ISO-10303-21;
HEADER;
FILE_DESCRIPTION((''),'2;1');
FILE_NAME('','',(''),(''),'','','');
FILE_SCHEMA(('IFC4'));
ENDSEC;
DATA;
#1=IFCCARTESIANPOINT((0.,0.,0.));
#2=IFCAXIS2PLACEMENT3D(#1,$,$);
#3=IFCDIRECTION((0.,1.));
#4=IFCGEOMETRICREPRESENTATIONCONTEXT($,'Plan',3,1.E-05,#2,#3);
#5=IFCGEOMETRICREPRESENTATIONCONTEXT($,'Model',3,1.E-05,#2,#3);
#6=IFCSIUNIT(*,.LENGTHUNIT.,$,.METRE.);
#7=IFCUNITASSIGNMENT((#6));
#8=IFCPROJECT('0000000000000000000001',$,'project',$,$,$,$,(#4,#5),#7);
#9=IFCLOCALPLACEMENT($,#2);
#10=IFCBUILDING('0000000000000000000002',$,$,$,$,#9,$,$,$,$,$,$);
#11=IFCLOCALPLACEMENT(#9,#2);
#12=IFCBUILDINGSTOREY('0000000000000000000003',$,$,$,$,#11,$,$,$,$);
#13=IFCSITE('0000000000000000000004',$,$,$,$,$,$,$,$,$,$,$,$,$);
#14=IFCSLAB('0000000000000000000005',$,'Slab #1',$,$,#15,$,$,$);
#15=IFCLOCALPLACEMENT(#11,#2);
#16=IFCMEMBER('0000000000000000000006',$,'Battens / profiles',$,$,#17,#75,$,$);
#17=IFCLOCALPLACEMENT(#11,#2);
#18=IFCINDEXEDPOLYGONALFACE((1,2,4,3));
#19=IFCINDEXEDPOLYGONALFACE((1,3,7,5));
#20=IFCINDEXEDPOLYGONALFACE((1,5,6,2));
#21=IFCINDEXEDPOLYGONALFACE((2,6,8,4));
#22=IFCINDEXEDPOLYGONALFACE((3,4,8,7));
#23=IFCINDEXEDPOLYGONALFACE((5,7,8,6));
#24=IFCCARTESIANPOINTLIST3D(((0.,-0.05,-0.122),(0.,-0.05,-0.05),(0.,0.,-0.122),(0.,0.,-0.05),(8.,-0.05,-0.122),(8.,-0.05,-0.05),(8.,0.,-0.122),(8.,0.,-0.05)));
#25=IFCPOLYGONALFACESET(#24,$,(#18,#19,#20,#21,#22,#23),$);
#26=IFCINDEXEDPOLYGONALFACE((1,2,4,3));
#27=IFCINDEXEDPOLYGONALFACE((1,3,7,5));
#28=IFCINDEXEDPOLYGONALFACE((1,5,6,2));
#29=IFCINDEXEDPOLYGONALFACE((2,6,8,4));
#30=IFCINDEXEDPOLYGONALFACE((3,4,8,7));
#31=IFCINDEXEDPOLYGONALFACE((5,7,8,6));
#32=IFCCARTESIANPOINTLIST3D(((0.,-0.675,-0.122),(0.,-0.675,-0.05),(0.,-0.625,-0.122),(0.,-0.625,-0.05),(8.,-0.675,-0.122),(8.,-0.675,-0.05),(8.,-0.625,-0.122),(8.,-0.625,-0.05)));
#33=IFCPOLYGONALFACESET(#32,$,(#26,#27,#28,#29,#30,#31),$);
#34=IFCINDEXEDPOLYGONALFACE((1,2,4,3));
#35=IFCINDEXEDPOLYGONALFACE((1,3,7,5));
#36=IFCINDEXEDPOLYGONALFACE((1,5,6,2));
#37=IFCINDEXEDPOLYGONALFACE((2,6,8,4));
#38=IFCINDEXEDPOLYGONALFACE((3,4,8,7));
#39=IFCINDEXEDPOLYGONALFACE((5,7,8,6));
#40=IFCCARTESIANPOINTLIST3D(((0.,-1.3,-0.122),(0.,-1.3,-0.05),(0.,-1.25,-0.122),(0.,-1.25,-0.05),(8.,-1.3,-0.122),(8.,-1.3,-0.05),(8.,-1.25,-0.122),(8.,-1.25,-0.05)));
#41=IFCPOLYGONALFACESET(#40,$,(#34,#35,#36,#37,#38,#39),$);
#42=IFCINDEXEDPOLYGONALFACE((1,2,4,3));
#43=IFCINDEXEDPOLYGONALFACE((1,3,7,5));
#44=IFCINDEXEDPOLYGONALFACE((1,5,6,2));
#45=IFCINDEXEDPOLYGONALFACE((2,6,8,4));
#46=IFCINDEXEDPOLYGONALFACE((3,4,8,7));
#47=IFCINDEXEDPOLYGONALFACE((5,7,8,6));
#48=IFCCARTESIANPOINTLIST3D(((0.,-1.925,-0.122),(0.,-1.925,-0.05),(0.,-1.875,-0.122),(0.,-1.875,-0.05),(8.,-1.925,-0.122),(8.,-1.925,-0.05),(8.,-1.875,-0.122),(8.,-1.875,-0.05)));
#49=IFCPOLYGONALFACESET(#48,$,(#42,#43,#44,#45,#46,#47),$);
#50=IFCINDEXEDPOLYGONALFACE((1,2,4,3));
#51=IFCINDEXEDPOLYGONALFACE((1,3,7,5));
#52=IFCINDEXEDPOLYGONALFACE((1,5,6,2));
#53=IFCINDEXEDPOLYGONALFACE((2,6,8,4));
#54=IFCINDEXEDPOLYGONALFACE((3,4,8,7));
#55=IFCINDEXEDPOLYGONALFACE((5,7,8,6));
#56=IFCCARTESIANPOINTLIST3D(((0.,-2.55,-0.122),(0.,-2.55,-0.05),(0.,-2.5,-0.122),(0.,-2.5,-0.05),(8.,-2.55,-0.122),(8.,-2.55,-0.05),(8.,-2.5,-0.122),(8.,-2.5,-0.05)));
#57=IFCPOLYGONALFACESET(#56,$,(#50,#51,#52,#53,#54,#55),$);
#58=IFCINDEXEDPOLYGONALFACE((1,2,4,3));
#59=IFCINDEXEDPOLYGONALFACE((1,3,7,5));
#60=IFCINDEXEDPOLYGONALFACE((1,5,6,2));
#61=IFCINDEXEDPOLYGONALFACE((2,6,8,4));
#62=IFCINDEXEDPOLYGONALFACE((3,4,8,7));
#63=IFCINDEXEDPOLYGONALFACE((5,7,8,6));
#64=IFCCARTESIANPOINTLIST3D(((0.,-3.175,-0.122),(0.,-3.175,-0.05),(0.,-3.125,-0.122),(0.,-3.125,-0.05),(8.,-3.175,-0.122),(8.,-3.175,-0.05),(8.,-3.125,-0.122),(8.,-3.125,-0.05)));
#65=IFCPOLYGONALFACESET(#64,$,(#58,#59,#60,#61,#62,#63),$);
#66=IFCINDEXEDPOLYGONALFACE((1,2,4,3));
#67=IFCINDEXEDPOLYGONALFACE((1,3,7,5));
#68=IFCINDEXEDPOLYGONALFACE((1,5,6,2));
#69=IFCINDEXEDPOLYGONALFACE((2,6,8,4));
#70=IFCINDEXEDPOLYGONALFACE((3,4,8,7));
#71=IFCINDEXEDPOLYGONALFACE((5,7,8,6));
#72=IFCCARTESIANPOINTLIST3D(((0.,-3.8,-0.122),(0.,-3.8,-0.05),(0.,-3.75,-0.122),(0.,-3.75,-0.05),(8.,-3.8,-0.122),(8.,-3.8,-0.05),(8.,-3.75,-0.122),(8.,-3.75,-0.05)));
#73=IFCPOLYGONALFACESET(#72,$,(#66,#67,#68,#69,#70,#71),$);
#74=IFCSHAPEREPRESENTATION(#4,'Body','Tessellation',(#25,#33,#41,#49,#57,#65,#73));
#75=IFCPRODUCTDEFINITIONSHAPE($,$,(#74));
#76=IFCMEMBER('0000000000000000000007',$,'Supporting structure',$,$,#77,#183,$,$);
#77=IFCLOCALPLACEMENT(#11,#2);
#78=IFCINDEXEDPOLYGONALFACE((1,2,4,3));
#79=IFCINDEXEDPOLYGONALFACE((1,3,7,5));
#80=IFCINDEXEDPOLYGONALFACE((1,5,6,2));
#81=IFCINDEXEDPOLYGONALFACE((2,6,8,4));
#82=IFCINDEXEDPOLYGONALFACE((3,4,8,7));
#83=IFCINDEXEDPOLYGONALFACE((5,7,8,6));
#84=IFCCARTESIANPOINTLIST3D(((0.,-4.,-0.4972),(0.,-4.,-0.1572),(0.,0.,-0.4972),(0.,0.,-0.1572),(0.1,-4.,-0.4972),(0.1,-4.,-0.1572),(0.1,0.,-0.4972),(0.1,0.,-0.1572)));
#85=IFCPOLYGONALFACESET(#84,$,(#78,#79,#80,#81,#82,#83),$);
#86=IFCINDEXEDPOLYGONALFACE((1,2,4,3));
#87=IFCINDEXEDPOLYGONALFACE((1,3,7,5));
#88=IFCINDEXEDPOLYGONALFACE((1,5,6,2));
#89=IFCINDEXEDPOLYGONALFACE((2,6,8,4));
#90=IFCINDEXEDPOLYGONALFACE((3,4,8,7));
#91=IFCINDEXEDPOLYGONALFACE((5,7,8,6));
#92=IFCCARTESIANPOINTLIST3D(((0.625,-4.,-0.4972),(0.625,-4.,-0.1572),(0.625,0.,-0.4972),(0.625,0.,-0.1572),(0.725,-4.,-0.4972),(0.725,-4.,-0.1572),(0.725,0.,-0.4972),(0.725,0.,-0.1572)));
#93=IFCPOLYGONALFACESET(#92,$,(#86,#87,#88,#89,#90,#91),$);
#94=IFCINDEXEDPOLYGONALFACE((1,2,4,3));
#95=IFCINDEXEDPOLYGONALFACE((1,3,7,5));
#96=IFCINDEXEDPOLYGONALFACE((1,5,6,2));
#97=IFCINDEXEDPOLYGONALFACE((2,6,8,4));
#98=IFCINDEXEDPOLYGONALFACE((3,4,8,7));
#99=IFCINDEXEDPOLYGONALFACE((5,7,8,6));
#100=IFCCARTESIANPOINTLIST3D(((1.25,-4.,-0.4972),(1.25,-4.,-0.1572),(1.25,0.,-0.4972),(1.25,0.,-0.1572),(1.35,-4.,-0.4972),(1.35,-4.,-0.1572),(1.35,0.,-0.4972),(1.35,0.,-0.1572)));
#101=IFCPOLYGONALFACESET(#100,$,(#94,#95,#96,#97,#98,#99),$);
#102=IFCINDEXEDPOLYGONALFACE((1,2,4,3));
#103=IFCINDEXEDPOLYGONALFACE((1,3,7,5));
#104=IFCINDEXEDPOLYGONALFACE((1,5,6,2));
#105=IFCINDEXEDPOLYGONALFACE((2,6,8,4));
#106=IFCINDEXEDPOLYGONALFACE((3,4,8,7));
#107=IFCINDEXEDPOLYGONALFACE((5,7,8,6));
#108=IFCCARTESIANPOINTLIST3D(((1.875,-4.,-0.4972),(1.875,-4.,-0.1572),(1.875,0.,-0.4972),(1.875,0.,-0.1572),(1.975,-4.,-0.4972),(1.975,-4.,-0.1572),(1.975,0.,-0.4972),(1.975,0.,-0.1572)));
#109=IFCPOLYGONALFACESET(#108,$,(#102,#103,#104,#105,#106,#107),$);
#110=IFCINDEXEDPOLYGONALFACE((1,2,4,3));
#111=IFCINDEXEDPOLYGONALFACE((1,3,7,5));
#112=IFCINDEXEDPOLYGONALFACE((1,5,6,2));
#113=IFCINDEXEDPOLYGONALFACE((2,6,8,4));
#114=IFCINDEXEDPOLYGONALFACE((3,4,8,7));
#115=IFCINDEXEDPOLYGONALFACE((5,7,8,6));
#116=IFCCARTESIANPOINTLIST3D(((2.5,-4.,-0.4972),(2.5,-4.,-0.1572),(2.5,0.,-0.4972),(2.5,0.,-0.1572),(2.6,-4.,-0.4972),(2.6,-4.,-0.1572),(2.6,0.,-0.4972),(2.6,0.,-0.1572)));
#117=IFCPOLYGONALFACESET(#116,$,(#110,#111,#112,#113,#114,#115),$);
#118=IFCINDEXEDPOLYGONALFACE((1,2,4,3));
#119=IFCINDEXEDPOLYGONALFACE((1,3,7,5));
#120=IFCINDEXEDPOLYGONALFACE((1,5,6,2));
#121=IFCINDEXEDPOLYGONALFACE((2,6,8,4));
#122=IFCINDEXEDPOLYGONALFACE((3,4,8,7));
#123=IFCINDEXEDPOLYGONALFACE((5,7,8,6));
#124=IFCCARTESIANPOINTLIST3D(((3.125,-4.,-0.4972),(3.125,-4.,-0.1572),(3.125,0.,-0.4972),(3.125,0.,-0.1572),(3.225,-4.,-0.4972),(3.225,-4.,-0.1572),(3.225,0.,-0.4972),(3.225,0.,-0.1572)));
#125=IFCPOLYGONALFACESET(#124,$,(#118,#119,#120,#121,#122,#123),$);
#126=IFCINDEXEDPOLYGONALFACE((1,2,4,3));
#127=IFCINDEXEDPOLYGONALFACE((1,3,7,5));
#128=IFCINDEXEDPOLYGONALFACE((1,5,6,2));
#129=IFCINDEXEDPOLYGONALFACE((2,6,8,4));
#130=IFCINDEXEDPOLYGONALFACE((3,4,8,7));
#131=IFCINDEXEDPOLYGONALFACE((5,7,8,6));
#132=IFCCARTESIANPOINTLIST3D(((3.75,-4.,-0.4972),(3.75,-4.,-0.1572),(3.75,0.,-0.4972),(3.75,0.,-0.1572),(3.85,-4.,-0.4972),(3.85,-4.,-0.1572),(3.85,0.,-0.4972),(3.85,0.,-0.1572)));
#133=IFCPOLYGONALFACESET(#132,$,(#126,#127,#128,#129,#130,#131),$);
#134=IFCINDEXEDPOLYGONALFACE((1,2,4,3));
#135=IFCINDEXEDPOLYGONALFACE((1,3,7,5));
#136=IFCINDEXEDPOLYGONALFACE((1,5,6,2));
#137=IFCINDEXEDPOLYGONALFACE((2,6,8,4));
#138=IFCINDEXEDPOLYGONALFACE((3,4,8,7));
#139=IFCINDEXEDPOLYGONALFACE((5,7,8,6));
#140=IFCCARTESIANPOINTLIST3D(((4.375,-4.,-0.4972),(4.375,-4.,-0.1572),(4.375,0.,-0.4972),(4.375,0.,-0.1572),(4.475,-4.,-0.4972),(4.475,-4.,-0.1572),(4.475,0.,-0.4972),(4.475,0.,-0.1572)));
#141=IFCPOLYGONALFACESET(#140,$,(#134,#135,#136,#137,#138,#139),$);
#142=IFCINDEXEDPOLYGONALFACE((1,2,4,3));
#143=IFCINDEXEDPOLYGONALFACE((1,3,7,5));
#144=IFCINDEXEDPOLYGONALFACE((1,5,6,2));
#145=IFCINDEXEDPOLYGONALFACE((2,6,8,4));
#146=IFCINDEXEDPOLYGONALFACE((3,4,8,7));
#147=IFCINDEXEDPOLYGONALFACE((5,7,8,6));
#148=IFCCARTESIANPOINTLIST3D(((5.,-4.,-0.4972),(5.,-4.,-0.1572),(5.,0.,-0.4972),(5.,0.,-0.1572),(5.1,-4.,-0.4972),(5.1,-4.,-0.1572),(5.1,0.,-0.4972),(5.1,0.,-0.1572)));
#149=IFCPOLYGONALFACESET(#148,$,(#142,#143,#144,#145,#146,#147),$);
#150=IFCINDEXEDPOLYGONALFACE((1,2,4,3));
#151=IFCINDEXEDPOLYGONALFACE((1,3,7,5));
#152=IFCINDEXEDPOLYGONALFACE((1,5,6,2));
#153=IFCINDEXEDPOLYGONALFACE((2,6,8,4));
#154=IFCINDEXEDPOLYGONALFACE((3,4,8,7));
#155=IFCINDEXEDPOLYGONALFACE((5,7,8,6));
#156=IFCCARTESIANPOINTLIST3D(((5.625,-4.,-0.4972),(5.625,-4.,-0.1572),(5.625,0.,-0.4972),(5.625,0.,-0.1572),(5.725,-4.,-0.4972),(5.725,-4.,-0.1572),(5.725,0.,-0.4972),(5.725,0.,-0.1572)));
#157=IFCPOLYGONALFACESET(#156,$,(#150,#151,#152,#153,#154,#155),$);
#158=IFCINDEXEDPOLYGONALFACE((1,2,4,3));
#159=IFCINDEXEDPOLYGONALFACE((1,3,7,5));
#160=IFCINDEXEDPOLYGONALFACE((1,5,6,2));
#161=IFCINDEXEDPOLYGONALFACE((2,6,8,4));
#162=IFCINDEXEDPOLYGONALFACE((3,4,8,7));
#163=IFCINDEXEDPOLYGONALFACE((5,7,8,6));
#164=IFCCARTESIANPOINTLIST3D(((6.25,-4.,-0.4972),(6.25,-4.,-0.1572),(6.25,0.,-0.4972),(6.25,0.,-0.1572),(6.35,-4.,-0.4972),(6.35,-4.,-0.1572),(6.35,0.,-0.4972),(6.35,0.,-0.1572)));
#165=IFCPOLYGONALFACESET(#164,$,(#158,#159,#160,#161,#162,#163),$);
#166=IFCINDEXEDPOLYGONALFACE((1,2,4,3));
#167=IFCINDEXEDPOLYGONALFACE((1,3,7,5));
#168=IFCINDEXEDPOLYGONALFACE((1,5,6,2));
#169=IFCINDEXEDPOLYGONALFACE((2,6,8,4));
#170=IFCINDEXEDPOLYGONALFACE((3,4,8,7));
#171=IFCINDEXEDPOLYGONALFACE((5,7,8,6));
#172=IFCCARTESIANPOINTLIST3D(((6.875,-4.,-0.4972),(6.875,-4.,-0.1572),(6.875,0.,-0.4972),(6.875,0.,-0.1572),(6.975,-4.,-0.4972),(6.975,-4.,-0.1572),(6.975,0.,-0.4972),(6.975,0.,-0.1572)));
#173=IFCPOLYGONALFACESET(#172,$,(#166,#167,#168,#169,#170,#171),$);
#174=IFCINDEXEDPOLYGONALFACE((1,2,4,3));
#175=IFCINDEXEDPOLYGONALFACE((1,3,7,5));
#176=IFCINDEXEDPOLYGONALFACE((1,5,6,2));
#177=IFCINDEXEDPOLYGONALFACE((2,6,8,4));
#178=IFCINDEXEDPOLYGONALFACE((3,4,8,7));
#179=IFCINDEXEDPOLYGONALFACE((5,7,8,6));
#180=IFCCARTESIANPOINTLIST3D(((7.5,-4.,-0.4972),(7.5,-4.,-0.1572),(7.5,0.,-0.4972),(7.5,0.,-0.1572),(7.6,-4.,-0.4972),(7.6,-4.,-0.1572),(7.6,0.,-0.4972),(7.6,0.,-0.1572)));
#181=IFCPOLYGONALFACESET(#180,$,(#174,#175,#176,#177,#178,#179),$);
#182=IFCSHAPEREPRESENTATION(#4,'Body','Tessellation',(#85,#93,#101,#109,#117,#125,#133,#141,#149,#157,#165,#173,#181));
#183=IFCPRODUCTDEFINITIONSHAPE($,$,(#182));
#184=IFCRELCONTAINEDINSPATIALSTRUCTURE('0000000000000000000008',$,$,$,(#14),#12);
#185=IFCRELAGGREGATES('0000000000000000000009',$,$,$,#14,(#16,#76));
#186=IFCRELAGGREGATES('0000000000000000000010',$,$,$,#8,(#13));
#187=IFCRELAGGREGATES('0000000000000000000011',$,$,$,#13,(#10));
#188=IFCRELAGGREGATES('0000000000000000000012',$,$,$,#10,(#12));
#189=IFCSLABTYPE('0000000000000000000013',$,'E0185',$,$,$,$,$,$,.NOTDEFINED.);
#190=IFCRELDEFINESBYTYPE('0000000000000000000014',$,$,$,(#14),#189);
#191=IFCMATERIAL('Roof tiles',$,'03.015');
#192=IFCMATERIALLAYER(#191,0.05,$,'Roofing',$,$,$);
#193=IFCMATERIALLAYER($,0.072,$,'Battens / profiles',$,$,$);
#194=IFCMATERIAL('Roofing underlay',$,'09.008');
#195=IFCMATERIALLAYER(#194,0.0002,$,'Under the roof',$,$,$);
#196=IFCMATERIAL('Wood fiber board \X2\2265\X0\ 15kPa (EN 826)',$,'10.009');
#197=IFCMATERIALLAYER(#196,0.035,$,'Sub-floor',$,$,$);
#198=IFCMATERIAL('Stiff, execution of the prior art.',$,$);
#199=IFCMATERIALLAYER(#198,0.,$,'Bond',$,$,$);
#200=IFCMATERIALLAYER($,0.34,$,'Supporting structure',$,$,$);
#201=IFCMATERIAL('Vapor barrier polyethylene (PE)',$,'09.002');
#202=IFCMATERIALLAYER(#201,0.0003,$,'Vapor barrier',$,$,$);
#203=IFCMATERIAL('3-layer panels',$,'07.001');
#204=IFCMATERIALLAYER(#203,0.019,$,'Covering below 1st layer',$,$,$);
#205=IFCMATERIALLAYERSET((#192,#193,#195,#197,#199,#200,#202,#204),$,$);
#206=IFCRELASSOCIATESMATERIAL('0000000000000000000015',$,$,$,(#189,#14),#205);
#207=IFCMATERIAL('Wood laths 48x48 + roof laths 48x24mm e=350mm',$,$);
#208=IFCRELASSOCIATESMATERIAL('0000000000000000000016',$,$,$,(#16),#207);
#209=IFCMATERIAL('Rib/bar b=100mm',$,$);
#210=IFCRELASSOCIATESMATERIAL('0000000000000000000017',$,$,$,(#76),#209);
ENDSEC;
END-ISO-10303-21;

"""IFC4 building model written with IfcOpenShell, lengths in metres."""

from ifc_helpers import new_model, si_unit, direction, frame, frame_2d, origin, place, context, project, spatial, rectangle, extrude, material, layer, layer_set, type_object, element, aggregate, save


model = new_model("IFC4")

# Units and contexts
plan_context = context("Plan", 3, precision=1e-05, world=origin(), true_north=direction((0.0, 1.0)))
model_context = context("Model", 3, precision=1e-05, world=origin(), true_north=direction((0.0, 1.0)))
ifc_project = project(units=[si_unit("LENGTHUNIT", "METRE")], contexts=[plan_context, model_context])

# Site, building, storey
site = spatial("IfcSite", under=ifc_project)
building_placement = place(None, origin())
building = spatial("IfcBuilding", under=site, at=building_placement)
storey_placement = place(building_placement, origin())
storey = spatial("IfcBuildingStorey", under=building, at=storey_placement)

# Slab, members
ifc_material_1 = material(Name="Roof tiles", Category="03.015")
ifc_layer_1 = layer(ifc_material_1, 0.05, Name="Roofing")
ifc_layer_2 = layer(None, 0.072, Name="Battens / profiles")
ifc_material_2 = material(Name="Roofing underlay", Category="09.008")
ifc_layer_3 = layer(ifc_material_2, 0.0002, Name="Under the roof")
ifc_material_3 = material(Name="Wood fiber board ≥ 15kPa (EN 826)", Category="10.009")
ifc_layer_4 = layer(ifc_material_3, 0.035, Name="Sub-floor")
ifc_material_4 = material(Name="Stiff, execution of the prior art.")
ifc_layer_5 = layer(ifc_material_4, 0.0, Name="Bond")
ifc_layer_6 = layer(None, 0.34, Name="Supporting structure")
ifc_material_5 = material(Name="Vapor barrier polyethylene (PE)", Category="09.002")
ifc_layer_7 = layer(ifc_material_5, 0.0003, Name="Vapor barrier")
ifc_material_6 = material(Name="3-layer panels", Category="07.001")
ifc_layer_8 = layer(ifc_material_6, 0.019, Name="Covering below 1st layer")
ifc_layer_set = layer_set([ifc_layer_1, ifc_layer_2, ifc_layer_3, ifc_layer_4, ifc_layer_5, ifc_layer_6, ifc_layer_7, ifc_layer_8])
slab_type = type_object("IfcSlabType", Name="E0185", PredefinedType="NOTDEFINED", material=ifc_layer_set)
slab_placement = place(None, frame((0.0, 0.0, 0.0), z_axis=(0.0, 0.0, -1.0), x_axis=(1.0, 0.0, 0.0)))
slab = element("IfcSlab", 1, at=slab_placement, inside=storey, type_object=slab_type, material=ifc_layer_set, Name="Slab #1")
ifc_material_7 = material(Name="Wood laths 48x48 + roof laths 48x24mm e=350mm")
member_1_placement = place(slab_placement, origin())
member_1 = element("IfcMember", 2, at=member_1_placement, material=ifc_material_7, Name="Battens / profiles", context=plan_context, shape_type="SweptSolid", body=[
    extrude(rectangle(XDim=0.05, YDim=0.072, at=frame_2d((0.025, 0.036), x_axis=(1.0, 0.0))), frame((0.0, 0.0, 0.05), z_axis=(1.0, 0.0, 0.0), x_axis=(0.0, 1.0, 0.0)), (0.0, 0.0, 1.0), 8.0),
    extrude(rectangle(XDim=0.05, YDim=0.072, at=frame_2d((0.025, 0.036), x_axis=(1.0, 0.0))), frame((0.0, 0.625, 0.05), z_axis=(1.0, 0.0, 0.0), x_axis=(0.0, 1.0, 0.0)), (0.0, 0.0, 1.0), 8.0),
    extrude(rectangle(XDim=0.05, YDim=0.072, at=frame_2d((0.025, 0.036), x_axis=(1.0, 0.0))), frame((0.0, 1.25, 0.05), z_axis=(1.0, 0.0, 0.0), x_axis=(0.0, 1.0, 0.0)), (0.0, 0.0, 1.0), 8.0),
    extrude(rectangle(XDim=0.05, YDim=0.072, at=frame_2d((0.025, 0.036), x_axis=(1.0, 0.0))), frame((0.0, 1.875, 0.05), z_axis=(1.0, 0.0, 0.0), x_axis=(0.0, 1.0, 0.0)), (0.0, 0.0, 1.0), 8.0),
    extrude(rectangle(XDim=0.05, YDim=0.072, at=frame_2d((0.025, 0.036), x_axis=(1.0, 0.0))), frame((0.0, 2.5, 0.05), z_axis=(1.0, 0.0, 0.0), x_axis=(0.0, 1.0, 0.0)), (0.0, 0.0, 1.0), 8.0),
    extrude(rectangle(XDim=0.05, YDim=0.072, at=frame_2d((0.025, 0.036), x_axis=(1.0, 0.0))), frame((0.0, 3.125, 0.05), z_axis=(1.0, 0.0, 0.0), x_axis=(0.0, 1.0, 0.0)), (0.0, 0.0, 1.0), 8.0),
    extrude(rectangle(XDim=0.05, YDim=0.072, at=frame_2d((0.025, 0.036), x_axis=(1.0, 0.0))), frame((0.0, 3.75, 0.05), z_axis=(1.0, 0.0, 0.0), x_axis=(0.0, 1.0, 0.0)), (0.0, 0.0, 1.0), 8.0),
])
ifc_material_8 = material(Name="Rib/bar b=100mm")
member_2_placement = place(slab_placement, origin())
member_2 = element("IfcMember", 3, at=member_2_placement, material=ifc_material_8, Name="Supporting structure", context=plan_context, shape_type="SweptSolid", body=[
    extrude(rectangle(XDim=0.1, YDim=0.34, at=frame_2d((0.05, 0.17), x_axis=(1.0, 0.0))), frame((0.0, 4.0, 0.1572), z_axis=(0.0, -1.0, 0.0), x_axis=(1.0, 0.0, 0.0)), (0.0, 0.0, 1.0), 4.0),
    extrude(rectangle(XDim=0.1, YDim=0.34, at=frame_2d((0.05, 0.17), x_axis=(1.0, 0.0))), frame((0.625, 4.0, 0.1572), z_axis=(0.0, -1.0, 0.0), x_axis=(1.0, 0.0, 0.0)), (0.0, 0.0, 1.0), 4.0),
    extrude(rectangle(XDim=0.1, YDim=0.34, at=frame_2d((0.05, 0.17), x_axis=(1.0, 0.0))), frame((1.25, 4.0, 0.1572), z_axis=(0.0, -1.0, 0.0), x_axis=(1.0, 0.0, 0.0)), (0.0, 0.0, 1.0), 4.0),
    extrude(rectangle(XDim=0.1, YDim=0.34, at=frame_2d((0.05, 0.17), x_axis=(1.0, 0.0))), frame((1.875, 4.0, 0.1572), z_axis=(0.0, -1.0, 0.0), x_axis=(1.0, 0.0, 0.0)), (0.0, 0.0, 1.0), 4.0),
    extrude(rectangle(XDim=0.1, YDim=0.34, at=frame_2d((0.05, 0.17), x_axis=(1.0, 0.0))), frame((2.5, 4.0, 0.1572), z_axis=(0.0, -1.0, 0.0), x_axis=(1.0, 0.0, 0.0)), (0.0, 0.0, 1.0), 4.0),
    extrude(rectangle(XDim=0.1, YDim=0.34, at=frame_2d((0.05, 0.17), x_axis=(1.0, 0.0))), frame((3.125, 4.0, 0.1572), z_axis=(0.0, -1.0, 0.0), x_axis=(1.0, 0.0, 0.0)), (0.0, 0.0, 1.0), 4.0),
    extrude(rectangle(XDim=0.1, YDim=0.34, at=frame_2d((0.05, 0.17), x_axis=(1.0, 0.0))), frame((3.75, 4.0, 0.1572), z_axis=(0.0, -1.0, 0.0), x_axis=(1.0, 0.0, 0.0)), (0.0, 0.0, 1.0), 4.0),
    extrude(rectangle(XDim=0.1, YDim=0.34, at=frame_2d((0.05, 0.17), x_axis=(1.0, 0.0))), frame((4.375, 4.0, 0.1572), z_axis=(0.0, -1.0, 0.0), x_axis=(1.0, 0.0, 0.0)), (0.0, 0.0, 1.0), 4.0),
    extrude(rectangle(XDim=0.1, YDim=0.34, at=frame_2d((0.05, 0.17), x_axis=(1.0, 0.0))), frame((5.0, 4.0, 0.1572), z_axis=(0.0, -1.0, 0.0), x_axis=(1.0, 0.0, 0.0)), (0.0, 0.0, 1.0), 4.0),
    extrude(rectangle(XDim=0.1, YDim=0.34, at=frame_2d((0.05, 0.17), x_axis=(1.0, 0.0))), frame((5.625, 4.0, 0.1572), z_axis=(0.0, -1.0, 0.0), x_axis=(1.0, 0.0, 0.0)), (0.0, 0.0, 1.0), 4.0),
    extrude(rectangle(XDim=0.1, YDim=0.34, at=frame_2d((0.05, 0.17), x_axis=(1.0, 0.0))), frame((6.25, 4.0, 0.1572), z_axis=(0.0, -1.0, 0.0), x_axis=(1.0, 0.0, 0.0)), (0.0, 0.0, 1.0), 4.0),
    extrude(rectangle(XDim=0.1, YDim=0.34, at=frame_2d((0.05, 0.17), x_axis=(1.0, 0.0))), frame((6.875, 4.0, 0.1572), z_axis=(0.0, -1.0, 0.0), x_axis=(1.0, 0.0, 0.0)), (0.0, 0.0, 1.0), 4.0),
    extrude(rectangle(XDim=0.1, YDim=0.34, at=frame_2d((0.05, 0.17), x_axis=(1.0, 0.0))), frame((7.5, 4.0, 0.1572), z_axis=(0.0, -1.0, 0.0), x_axis=(1.0, 0.0, 0.0)), (0.0, 0.0, 1.0), 4.0),
])
aggregate(slab, [member_1, member_2])

save(model, "model.ifc")
